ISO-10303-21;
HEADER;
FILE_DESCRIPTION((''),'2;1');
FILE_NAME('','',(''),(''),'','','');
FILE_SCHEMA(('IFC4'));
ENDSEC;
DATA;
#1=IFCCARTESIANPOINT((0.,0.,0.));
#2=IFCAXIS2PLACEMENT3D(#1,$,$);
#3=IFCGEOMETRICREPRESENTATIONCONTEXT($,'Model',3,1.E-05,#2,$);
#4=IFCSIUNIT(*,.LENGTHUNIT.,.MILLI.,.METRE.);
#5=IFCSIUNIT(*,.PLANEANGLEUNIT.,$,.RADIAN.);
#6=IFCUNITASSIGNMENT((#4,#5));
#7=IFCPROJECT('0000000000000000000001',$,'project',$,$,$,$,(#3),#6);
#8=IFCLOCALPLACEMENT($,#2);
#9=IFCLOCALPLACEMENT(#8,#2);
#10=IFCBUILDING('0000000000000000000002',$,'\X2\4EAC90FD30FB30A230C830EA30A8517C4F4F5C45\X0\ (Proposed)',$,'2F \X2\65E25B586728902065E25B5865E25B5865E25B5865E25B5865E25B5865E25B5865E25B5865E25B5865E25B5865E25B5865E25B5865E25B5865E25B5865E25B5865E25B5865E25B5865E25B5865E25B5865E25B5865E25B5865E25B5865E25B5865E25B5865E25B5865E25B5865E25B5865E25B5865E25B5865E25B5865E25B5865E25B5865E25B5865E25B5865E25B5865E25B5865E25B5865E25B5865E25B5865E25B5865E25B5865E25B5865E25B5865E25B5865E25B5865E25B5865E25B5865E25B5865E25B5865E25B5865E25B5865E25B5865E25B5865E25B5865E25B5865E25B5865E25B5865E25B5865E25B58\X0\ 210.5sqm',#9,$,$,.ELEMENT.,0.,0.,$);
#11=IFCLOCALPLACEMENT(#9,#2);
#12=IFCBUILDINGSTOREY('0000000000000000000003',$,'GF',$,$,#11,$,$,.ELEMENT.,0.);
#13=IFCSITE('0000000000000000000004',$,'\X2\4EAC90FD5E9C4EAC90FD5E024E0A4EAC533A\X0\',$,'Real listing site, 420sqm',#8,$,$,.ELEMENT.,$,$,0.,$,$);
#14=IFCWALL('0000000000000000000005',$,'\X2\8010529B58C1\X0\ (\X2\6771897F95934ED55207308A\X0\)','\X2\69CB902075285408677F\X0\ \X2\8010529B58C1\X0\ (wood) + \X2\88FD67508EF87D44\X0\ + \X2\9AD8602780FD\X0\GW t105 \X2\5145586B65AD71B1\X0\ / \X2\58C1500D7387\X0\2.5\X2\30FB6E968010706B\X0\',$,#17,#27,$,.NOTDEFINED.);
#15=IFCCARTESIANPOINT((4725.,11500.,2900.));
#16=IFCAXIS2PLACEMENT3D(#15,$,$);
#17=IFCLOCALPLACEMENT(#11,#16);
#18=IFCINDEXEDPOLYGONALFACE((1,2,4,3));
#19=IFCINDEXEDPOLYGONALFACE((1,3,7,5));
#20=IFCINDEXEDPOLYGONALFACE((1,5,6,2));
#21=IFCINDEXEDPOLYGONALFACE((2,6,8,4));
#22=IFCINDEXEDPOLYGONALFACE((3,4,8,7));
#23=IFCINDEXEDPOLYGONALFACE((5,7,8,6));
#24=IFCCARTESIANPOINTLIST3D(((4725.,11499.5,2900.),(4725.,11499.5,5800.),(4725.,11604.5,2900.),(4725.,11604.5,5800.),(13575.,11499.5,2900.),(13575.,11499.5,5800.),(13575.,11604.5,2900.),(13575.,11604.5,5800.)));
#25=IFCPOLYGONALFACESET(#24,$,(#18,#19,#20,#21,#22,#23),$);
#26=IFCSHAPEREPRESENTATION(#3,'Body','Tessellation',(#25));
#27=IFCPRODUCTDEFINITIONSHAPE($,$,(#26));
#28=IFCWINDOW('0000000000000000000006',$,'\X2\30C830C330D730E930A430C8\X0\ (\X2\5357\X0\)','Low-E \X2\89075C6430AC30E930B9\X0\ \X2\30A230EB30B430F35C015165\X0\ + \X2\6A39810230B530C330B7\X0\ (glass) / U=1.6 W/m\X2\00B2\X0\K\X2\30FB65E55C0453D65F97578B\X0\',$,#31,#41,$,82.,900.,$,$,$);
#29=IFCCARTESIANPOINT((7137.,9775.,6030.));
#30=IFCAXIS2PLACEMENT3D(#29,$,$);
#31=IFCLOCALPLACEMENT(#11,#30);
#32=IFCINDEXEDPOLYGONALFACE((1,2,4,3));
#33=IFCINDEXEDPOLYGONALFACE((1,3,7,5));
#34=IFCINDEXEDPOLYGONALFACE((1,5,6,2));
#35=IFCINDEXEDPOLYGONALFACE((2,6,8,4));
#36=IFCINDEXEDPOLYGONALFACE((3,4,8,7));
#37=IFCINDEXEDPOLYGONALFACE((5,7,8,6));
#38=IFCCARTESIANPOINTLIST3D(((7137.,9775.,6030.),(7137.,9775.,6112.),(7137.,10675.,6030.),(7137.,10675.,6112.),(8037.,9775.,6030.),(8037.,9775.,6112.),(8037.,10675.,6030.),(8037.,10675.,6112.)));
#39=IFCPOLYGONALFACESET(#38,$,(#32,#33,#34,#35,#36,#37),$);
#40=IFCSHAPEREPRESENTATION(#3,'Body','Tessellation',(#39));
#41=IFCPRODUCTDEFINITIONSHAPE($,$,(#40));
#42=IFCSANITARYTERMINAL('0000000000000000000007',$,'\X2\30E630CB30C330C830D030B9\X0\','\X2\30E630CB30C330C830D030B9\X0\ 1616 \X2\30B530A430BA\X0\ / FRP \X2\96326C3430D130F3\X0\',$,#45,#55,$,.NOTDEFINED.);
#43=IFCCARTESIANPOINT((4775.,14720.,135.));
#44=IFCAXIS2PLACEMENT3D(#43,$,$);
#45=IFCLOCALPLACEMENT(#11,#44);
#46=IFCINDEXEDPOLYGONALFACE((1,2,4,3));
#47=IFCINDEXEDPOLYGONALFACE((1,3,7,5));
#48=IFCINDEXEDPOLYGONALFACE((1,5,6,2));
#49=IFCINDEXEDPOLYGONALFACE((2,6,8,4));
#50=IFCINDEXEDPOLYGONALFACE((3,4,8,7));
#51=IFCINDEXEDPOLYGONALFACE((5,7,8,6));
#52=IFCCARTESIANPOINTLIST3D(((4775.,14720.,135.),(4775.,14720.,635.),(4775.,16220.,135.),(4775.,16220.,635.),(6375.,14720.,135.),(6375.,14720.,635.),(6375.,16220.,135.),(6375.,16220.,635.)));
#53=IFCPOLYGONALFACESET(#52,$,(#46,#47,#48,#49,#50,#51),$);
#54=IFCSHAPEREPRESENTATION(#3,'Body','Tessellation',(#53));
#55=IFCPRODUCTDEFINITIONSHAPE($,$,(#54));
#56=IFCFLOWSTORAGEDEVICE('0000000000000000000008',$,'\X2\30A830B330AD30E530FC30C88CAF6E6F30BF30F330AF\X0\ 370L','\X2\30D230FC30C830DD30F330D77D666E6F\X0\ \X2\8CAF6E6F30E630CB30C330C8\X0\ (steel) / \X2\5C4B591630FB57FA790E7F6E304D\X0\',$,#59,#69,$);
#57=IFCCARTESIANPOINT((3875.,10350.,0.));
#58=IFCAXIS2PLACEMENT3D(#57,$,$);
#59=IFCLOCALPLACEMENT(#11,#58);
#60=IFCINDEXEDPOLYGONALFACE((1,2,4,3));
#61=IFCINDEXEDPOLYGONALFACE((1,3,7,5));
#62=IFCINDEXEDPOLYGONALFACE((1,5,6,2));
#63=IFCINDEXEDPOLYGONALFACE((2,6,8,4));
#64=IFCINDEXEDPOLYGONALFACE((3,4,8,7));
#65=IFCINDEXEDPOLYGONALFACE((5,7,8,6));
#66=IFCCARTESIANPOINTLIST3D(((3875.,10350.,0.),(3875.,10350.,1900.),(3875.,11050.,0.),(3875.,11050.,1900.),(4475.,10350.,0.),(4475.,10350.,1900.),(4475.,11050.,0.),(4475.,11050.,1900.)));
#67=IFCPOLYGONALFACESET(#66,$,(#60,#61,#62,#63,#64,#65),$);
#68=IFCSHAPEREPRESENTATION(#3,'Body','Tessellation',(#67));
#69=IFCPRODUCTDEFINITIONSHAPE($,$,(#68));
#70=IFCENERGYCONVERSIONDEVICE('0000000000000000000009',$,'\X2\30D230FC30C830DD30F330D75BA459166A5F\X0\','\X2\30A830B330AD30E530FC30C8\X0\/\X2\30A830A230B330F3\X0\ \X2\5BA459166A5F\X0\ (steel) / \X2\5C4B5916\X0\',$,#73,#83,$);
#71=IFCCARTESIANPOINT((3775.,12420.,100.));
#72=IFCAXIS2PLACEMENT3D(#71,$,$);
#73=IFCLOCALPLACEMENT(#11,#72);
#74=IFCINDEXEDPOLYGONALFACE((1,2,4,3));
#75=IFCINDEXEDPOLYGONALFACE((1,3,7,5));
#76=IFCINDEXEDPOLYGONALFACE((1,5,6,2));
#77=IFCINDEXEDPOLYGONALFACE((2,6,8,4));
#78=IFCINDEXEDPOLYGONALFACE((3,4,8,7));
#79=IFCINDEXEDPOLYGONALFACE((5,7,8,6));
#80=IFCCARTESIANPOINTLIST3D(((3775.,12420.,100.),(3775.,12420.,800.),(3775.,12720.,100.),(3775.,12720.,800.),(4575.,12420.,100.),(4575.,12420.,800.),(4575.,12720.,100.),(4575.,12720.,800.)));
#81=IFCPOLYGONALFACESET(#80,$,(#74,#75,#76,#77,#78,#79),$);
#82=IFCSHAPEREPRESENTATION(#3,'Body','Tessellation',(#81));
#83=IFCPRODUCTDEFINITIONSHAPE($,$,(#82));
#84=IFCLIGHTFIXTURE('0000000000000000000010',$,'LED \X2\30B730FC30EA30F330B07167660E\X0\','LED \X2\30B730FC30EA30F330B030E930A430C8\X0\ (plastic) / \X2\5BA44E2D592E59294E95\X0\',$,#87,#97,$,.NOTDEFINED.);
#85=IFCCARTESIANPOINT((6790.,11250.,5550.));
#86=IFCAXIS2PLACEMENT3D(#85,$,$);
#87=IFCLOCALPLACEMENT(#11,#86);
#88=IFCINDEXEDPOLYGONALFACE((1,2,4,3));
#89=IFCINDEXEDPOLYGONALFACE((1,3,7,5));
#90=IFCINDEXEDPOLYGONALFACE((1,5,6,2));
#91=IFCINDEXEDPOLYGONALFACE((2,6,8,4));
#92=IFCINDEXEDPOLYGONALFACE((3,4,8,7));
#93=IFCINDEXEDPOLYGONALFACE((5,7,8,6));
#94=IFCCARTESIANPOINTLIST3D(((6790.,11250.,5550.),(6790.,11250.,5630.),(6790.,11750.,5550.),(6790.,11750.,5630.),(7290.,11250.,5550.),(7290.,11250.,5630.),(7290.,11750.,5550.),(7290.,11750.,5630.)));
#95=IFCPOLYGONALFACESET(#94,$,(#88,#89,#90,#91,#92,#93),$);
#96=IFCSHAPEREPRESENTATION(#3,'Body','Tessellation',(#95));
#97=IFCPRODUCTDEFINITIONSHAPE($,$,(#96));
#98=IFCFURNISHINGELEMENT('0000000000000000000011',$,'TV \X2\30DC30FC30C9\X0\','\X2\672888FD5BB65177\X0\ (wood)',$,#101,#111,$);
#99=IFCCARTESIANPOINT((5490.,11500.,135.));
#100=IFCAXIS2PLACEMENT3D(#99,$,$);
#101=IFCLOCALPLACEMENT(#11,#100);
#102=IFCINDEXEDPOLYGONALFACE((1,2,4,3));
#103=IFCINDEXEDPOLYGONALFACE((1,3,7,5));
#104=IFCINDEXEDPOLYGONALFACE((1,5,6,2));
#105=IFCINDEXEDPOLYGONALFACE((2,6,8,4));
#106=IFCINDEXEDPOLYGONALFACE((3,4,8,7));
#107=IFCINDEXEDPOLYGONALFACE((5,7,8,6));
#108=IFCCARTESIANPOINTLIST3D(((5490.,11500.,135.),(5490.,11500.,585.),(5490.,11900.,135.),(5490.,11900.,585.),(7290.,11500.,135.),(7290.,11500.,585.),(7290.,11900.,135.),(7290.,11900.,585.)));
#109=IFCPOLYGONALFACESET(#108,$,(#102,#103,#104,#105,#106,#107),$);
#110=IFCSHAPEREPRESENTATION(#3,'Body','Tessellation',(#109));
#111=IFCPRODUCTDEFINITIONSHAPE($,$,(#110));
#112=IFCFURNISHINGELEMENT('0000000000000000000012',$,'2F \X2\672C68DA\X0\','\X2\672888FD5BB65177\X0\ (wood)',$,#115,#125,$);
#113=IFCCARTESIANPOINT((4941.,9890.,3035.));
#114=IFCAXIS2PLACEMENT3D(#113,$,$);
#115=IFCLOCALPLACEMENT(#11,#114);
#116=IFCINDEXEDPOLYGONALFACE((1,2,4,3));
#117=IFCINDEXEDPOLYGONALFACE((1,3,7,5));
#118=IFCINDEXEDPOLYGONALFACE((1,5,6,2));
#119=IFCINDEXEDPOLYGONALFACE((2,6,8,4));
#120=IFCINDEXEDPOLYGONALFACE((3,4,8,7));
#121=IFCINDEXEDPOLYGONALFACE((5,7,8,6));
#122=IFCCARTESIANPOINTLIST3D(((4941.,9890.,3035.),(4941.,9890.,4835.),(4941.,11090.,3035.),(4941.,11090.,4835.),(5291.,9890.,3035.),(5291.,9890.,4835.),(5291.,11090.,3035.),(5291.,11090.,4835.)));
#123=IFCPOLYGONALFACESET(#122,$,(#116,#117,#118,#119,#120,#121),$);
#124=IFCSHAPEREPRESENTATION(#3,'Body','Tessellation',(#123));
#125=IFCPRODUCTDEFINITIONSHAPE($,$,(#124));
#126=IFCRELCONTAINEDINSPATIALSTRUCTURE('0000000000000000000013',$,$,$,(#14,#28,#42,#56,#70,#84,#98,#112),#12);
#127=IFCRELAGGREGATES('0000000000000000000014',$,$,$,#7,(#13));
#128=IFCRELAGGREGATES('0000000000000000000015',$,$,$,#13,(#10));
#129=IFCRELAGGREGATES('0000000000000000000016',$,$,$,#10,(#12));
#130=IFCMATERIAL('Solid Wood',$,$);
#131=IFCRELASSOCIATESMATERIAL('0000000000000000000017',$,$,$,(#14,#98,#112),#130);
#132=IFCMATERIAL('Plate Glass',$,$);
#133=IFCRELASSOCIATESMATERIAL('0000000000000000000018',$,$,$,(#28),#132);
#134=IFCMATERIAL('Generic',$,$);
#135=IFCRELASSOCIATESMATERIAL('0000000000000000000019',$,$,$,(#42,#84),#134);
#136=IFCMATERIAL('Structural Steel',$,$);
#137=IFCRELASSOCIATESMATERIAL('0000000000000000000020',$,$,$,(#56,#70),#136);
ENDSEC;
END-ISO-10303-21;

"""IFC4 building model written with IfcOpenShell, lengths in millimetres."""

from ifc_helpers import new_model, si_unit, frame, frame_2d, origin, place, context, project, spatial, rectangle, extrude, material, element, save


model = new_model("IFC4")

# Units and contexts
model_context = context("Model", 3, precision=1e-05, world=origin())
ifc_project = project(units=[si_unit("LENGTHUNIT", "METRE", prefix="MILLI"), si_unit("PLANEANGLEUNIT", "RADIAN")], contexts=[model_context])

# Site, building, storey
site_placement = place(None, origin())
site = spatial("IfcSite", under=ifc_project, at=site_placement, Name="京都府京都市上京区", ObjectType="Real listing site, 420sqm", CompositionType="ELEMENT", RefElevation=0.0)
building_placement = place(site_placement, origin())
building = spatial("IfcBuilding", under=site, at=building_placement, Name="京都・アトリエ兼住居 (Proposed)", ObjectType="2F 既存木造既存既存既存既存既存既存既存既存既存既存既存既存既存既存既存既存既存既存既存既存既存既存既存既存既存既存既存既存既存既存既存既存既存既存既存既存既存既存既存既存既存既存既存既存既存既存既存既存既存既存既存既存既存既存既存既存既存既存 210.5sqm", CompositionType="ELEMENT", ElevationOfRefHeight=0.0, ElevationOfTerrain=0.0)
storey_placement = place(building_placement, origin())
storey = spatial("IfcBuildingStorey", under=building, at=storey_placement, Name="GF", CompositionType="ELEMENT", Elevation=0.0)

# Shared definitions
ifc_material_1 = material(Name="Solid Wood")

# Wall
wall_1_placement = place(storey_placement, frame((4725.0, 11500.0, 2900.0)))
element("IfcWall", 1, at=wall_1_placement, inside=storey, material=ifc_material_1, Name="耐力壁 (東西間仕切り)", Description="構造用合板 耐力壁 (wood) + 製材軸組 + 高性能GW t105 充填断熱 / 壁倍率2.5・準耐火", PredefinedType="NOTDEFINED", context=model_context, shape_type="SweptSolid", body=[
    extrude(rectangle(XDim=8850.0, YDim=105.0, at=frame_2d((4425.0, 52.0))), frame((4725.0, 11500.0, 2900.0)), (0.0, 0.0, 1.0), 2900.0),
])

# Window
ifc_material_2 = material(Name="Plate Glass")
window_placement = place(storey_placement, frame((7137.0, 9775.0, 6030.0)))
element("IfcWindow", 2, at=window_placement, inside=storey, material=ifc_material_2, Name="トップライト (南)", Description="Low-E 複層ガラス アルゴン封入 + 樹脂サッシ (glass) / U=1.6 W/m²K・日射取得型", OverallHeight=82.0, OverallWidth=900.0, context=model_context, shape_type="SweptSolid", body=[
    extrude(rectangle(XDim=900.0, YDim=900.0, at=frame_2d((450.0, 450.0))), frame((7137.0, 9775.0, 6030.0)), (0.0, 0.0, 1.0), 82.0),
])

# Sanitary terminal
ifc_material_3 = material(Name="Generic")
sanitary_terminal_placement = place(storey_placement, frame((4775.0, 14720.0, 135.0)))
element("IfcSanitaryTerminal", 3, at=sanitary_terminal_placement, inside=storey, material=ifc_material_3, Name="ユニットバス", Description="ユニットバス 1616 サイズ / FRP 防水パン", PredefinedType="NOTDEFINED", context=model_context, shape_type="SweptSolid", body=[
    extrude(rectangle(XDim=1600.0, YDim=1500.0, at=frame_2d((800.0, 750.0))), frame((4775.0, 14720.0, 135.0)), (0.0, 0.0, 1.0), 500.0),
])

# Flow storage device
ifc_material_4 = material(Name="Structural Steel")
flow_storage_device_placement = place(storey_placement, frame((3875.0, 10350.0, 0.0)))
element("IfcFlowStorageDevice", 4, at=flow_storage_device_placement, inside=storey, material=ifc_material_4, Name="エコキュート貯湯タンク 370L", Description="ヒートポンプ給湯 貯湯ユニット (steel) / 屋外・基礎置き", context=model_context, shape_type="SweptSolid", body=[
    extrude(rectangle(XDim=600.0, YDim=700.0, at=frame_2d((300.0, 350.0))), frame((3875.0, 10350.0, 0.0)), (0.0, 0.0, 1.0), 1900.0),
])

# Energy conversion device
energy_conversion_device_placement = place(storey_placement, frame((3775.0, 12420.0, 100.0)))
element("IfcEnergyConversionDevice", 5, at=energy_conversion_device_placement, inside=storey, material=ifc_material_4, Name="ヒートポンプ室外機", Description="エコキュート/エアコン 室外機 (steel) / 屋外", context=model_context, shape_type="SweptSolid", body=[
    extrude(rectangle(XDim=800.0, YDim=300.0, at=frame_2d((400.0, 150.0))), frame((3775.0, 12420.0, 100.0)), (0.0, 0.0, 1.0), 700.0),
])

# Light fixture
light_fixture_placement = place(storey_placement, frame((6790.0, 11250.0, 5550.0)))
element("IfcLightFixture", 6, at=light_fixture_placement, inside=storey, material=ifc_material_3, Name="LED シーリング照明", Description="LED シーリングライト (plastic) / 室中央天井", PredefinedType="NOTDEFINED", context=model_context, shape_type="SweptSolid", body=[
    extrude(rectangle(XDim=500.0, YDim=500.0, at=frame_2d((250.0, 250.0))), frame((6790.0, 11250.0, 5550.0)), (0.0, 0.0, 1.0), 80.0),
])

# Furnishing elements
furnishing_1_placement = place(storey_placement, frame((5490.0, 11500.0, 135.0)))
element("IfcFurnishingElement", 7, at=furnishing_1_placement, inside=storey, material=ifc_material_1, Name="TV ボード", Description="木製家具 (wood)", context=model_context, shape_type="SweptSolid", body=[
    extrude(rectangle(XDim=1800.0, YDim=400.0, at=frame_2d((900.0, 200.0))), frame((5490.0, 11500.0, 135.0)), (0.0, 0.0, 1.0), 450.0),
])
furnishing_2_placement = place(storey_placement, frame((4941.0, 9890.0, 3035.0)))
element("IfcFurnishingElement", 8, at=furnishing_2_placement, inside=storey, material=ifc_material_1, Name="2F 本棚", Description="木製家具 (wood)", context=model_context, shape_type="SweptSolid", body=[
    extrude(rectangle(XDim=350.0, YDim=1200.0, at=frame_2d((175.0, 600.0))), frame((4941.0, 9890.0, 3035.0)), (0.0, 0.0, 1.0), 1800.0),
])

save(model, "model.ifc")
